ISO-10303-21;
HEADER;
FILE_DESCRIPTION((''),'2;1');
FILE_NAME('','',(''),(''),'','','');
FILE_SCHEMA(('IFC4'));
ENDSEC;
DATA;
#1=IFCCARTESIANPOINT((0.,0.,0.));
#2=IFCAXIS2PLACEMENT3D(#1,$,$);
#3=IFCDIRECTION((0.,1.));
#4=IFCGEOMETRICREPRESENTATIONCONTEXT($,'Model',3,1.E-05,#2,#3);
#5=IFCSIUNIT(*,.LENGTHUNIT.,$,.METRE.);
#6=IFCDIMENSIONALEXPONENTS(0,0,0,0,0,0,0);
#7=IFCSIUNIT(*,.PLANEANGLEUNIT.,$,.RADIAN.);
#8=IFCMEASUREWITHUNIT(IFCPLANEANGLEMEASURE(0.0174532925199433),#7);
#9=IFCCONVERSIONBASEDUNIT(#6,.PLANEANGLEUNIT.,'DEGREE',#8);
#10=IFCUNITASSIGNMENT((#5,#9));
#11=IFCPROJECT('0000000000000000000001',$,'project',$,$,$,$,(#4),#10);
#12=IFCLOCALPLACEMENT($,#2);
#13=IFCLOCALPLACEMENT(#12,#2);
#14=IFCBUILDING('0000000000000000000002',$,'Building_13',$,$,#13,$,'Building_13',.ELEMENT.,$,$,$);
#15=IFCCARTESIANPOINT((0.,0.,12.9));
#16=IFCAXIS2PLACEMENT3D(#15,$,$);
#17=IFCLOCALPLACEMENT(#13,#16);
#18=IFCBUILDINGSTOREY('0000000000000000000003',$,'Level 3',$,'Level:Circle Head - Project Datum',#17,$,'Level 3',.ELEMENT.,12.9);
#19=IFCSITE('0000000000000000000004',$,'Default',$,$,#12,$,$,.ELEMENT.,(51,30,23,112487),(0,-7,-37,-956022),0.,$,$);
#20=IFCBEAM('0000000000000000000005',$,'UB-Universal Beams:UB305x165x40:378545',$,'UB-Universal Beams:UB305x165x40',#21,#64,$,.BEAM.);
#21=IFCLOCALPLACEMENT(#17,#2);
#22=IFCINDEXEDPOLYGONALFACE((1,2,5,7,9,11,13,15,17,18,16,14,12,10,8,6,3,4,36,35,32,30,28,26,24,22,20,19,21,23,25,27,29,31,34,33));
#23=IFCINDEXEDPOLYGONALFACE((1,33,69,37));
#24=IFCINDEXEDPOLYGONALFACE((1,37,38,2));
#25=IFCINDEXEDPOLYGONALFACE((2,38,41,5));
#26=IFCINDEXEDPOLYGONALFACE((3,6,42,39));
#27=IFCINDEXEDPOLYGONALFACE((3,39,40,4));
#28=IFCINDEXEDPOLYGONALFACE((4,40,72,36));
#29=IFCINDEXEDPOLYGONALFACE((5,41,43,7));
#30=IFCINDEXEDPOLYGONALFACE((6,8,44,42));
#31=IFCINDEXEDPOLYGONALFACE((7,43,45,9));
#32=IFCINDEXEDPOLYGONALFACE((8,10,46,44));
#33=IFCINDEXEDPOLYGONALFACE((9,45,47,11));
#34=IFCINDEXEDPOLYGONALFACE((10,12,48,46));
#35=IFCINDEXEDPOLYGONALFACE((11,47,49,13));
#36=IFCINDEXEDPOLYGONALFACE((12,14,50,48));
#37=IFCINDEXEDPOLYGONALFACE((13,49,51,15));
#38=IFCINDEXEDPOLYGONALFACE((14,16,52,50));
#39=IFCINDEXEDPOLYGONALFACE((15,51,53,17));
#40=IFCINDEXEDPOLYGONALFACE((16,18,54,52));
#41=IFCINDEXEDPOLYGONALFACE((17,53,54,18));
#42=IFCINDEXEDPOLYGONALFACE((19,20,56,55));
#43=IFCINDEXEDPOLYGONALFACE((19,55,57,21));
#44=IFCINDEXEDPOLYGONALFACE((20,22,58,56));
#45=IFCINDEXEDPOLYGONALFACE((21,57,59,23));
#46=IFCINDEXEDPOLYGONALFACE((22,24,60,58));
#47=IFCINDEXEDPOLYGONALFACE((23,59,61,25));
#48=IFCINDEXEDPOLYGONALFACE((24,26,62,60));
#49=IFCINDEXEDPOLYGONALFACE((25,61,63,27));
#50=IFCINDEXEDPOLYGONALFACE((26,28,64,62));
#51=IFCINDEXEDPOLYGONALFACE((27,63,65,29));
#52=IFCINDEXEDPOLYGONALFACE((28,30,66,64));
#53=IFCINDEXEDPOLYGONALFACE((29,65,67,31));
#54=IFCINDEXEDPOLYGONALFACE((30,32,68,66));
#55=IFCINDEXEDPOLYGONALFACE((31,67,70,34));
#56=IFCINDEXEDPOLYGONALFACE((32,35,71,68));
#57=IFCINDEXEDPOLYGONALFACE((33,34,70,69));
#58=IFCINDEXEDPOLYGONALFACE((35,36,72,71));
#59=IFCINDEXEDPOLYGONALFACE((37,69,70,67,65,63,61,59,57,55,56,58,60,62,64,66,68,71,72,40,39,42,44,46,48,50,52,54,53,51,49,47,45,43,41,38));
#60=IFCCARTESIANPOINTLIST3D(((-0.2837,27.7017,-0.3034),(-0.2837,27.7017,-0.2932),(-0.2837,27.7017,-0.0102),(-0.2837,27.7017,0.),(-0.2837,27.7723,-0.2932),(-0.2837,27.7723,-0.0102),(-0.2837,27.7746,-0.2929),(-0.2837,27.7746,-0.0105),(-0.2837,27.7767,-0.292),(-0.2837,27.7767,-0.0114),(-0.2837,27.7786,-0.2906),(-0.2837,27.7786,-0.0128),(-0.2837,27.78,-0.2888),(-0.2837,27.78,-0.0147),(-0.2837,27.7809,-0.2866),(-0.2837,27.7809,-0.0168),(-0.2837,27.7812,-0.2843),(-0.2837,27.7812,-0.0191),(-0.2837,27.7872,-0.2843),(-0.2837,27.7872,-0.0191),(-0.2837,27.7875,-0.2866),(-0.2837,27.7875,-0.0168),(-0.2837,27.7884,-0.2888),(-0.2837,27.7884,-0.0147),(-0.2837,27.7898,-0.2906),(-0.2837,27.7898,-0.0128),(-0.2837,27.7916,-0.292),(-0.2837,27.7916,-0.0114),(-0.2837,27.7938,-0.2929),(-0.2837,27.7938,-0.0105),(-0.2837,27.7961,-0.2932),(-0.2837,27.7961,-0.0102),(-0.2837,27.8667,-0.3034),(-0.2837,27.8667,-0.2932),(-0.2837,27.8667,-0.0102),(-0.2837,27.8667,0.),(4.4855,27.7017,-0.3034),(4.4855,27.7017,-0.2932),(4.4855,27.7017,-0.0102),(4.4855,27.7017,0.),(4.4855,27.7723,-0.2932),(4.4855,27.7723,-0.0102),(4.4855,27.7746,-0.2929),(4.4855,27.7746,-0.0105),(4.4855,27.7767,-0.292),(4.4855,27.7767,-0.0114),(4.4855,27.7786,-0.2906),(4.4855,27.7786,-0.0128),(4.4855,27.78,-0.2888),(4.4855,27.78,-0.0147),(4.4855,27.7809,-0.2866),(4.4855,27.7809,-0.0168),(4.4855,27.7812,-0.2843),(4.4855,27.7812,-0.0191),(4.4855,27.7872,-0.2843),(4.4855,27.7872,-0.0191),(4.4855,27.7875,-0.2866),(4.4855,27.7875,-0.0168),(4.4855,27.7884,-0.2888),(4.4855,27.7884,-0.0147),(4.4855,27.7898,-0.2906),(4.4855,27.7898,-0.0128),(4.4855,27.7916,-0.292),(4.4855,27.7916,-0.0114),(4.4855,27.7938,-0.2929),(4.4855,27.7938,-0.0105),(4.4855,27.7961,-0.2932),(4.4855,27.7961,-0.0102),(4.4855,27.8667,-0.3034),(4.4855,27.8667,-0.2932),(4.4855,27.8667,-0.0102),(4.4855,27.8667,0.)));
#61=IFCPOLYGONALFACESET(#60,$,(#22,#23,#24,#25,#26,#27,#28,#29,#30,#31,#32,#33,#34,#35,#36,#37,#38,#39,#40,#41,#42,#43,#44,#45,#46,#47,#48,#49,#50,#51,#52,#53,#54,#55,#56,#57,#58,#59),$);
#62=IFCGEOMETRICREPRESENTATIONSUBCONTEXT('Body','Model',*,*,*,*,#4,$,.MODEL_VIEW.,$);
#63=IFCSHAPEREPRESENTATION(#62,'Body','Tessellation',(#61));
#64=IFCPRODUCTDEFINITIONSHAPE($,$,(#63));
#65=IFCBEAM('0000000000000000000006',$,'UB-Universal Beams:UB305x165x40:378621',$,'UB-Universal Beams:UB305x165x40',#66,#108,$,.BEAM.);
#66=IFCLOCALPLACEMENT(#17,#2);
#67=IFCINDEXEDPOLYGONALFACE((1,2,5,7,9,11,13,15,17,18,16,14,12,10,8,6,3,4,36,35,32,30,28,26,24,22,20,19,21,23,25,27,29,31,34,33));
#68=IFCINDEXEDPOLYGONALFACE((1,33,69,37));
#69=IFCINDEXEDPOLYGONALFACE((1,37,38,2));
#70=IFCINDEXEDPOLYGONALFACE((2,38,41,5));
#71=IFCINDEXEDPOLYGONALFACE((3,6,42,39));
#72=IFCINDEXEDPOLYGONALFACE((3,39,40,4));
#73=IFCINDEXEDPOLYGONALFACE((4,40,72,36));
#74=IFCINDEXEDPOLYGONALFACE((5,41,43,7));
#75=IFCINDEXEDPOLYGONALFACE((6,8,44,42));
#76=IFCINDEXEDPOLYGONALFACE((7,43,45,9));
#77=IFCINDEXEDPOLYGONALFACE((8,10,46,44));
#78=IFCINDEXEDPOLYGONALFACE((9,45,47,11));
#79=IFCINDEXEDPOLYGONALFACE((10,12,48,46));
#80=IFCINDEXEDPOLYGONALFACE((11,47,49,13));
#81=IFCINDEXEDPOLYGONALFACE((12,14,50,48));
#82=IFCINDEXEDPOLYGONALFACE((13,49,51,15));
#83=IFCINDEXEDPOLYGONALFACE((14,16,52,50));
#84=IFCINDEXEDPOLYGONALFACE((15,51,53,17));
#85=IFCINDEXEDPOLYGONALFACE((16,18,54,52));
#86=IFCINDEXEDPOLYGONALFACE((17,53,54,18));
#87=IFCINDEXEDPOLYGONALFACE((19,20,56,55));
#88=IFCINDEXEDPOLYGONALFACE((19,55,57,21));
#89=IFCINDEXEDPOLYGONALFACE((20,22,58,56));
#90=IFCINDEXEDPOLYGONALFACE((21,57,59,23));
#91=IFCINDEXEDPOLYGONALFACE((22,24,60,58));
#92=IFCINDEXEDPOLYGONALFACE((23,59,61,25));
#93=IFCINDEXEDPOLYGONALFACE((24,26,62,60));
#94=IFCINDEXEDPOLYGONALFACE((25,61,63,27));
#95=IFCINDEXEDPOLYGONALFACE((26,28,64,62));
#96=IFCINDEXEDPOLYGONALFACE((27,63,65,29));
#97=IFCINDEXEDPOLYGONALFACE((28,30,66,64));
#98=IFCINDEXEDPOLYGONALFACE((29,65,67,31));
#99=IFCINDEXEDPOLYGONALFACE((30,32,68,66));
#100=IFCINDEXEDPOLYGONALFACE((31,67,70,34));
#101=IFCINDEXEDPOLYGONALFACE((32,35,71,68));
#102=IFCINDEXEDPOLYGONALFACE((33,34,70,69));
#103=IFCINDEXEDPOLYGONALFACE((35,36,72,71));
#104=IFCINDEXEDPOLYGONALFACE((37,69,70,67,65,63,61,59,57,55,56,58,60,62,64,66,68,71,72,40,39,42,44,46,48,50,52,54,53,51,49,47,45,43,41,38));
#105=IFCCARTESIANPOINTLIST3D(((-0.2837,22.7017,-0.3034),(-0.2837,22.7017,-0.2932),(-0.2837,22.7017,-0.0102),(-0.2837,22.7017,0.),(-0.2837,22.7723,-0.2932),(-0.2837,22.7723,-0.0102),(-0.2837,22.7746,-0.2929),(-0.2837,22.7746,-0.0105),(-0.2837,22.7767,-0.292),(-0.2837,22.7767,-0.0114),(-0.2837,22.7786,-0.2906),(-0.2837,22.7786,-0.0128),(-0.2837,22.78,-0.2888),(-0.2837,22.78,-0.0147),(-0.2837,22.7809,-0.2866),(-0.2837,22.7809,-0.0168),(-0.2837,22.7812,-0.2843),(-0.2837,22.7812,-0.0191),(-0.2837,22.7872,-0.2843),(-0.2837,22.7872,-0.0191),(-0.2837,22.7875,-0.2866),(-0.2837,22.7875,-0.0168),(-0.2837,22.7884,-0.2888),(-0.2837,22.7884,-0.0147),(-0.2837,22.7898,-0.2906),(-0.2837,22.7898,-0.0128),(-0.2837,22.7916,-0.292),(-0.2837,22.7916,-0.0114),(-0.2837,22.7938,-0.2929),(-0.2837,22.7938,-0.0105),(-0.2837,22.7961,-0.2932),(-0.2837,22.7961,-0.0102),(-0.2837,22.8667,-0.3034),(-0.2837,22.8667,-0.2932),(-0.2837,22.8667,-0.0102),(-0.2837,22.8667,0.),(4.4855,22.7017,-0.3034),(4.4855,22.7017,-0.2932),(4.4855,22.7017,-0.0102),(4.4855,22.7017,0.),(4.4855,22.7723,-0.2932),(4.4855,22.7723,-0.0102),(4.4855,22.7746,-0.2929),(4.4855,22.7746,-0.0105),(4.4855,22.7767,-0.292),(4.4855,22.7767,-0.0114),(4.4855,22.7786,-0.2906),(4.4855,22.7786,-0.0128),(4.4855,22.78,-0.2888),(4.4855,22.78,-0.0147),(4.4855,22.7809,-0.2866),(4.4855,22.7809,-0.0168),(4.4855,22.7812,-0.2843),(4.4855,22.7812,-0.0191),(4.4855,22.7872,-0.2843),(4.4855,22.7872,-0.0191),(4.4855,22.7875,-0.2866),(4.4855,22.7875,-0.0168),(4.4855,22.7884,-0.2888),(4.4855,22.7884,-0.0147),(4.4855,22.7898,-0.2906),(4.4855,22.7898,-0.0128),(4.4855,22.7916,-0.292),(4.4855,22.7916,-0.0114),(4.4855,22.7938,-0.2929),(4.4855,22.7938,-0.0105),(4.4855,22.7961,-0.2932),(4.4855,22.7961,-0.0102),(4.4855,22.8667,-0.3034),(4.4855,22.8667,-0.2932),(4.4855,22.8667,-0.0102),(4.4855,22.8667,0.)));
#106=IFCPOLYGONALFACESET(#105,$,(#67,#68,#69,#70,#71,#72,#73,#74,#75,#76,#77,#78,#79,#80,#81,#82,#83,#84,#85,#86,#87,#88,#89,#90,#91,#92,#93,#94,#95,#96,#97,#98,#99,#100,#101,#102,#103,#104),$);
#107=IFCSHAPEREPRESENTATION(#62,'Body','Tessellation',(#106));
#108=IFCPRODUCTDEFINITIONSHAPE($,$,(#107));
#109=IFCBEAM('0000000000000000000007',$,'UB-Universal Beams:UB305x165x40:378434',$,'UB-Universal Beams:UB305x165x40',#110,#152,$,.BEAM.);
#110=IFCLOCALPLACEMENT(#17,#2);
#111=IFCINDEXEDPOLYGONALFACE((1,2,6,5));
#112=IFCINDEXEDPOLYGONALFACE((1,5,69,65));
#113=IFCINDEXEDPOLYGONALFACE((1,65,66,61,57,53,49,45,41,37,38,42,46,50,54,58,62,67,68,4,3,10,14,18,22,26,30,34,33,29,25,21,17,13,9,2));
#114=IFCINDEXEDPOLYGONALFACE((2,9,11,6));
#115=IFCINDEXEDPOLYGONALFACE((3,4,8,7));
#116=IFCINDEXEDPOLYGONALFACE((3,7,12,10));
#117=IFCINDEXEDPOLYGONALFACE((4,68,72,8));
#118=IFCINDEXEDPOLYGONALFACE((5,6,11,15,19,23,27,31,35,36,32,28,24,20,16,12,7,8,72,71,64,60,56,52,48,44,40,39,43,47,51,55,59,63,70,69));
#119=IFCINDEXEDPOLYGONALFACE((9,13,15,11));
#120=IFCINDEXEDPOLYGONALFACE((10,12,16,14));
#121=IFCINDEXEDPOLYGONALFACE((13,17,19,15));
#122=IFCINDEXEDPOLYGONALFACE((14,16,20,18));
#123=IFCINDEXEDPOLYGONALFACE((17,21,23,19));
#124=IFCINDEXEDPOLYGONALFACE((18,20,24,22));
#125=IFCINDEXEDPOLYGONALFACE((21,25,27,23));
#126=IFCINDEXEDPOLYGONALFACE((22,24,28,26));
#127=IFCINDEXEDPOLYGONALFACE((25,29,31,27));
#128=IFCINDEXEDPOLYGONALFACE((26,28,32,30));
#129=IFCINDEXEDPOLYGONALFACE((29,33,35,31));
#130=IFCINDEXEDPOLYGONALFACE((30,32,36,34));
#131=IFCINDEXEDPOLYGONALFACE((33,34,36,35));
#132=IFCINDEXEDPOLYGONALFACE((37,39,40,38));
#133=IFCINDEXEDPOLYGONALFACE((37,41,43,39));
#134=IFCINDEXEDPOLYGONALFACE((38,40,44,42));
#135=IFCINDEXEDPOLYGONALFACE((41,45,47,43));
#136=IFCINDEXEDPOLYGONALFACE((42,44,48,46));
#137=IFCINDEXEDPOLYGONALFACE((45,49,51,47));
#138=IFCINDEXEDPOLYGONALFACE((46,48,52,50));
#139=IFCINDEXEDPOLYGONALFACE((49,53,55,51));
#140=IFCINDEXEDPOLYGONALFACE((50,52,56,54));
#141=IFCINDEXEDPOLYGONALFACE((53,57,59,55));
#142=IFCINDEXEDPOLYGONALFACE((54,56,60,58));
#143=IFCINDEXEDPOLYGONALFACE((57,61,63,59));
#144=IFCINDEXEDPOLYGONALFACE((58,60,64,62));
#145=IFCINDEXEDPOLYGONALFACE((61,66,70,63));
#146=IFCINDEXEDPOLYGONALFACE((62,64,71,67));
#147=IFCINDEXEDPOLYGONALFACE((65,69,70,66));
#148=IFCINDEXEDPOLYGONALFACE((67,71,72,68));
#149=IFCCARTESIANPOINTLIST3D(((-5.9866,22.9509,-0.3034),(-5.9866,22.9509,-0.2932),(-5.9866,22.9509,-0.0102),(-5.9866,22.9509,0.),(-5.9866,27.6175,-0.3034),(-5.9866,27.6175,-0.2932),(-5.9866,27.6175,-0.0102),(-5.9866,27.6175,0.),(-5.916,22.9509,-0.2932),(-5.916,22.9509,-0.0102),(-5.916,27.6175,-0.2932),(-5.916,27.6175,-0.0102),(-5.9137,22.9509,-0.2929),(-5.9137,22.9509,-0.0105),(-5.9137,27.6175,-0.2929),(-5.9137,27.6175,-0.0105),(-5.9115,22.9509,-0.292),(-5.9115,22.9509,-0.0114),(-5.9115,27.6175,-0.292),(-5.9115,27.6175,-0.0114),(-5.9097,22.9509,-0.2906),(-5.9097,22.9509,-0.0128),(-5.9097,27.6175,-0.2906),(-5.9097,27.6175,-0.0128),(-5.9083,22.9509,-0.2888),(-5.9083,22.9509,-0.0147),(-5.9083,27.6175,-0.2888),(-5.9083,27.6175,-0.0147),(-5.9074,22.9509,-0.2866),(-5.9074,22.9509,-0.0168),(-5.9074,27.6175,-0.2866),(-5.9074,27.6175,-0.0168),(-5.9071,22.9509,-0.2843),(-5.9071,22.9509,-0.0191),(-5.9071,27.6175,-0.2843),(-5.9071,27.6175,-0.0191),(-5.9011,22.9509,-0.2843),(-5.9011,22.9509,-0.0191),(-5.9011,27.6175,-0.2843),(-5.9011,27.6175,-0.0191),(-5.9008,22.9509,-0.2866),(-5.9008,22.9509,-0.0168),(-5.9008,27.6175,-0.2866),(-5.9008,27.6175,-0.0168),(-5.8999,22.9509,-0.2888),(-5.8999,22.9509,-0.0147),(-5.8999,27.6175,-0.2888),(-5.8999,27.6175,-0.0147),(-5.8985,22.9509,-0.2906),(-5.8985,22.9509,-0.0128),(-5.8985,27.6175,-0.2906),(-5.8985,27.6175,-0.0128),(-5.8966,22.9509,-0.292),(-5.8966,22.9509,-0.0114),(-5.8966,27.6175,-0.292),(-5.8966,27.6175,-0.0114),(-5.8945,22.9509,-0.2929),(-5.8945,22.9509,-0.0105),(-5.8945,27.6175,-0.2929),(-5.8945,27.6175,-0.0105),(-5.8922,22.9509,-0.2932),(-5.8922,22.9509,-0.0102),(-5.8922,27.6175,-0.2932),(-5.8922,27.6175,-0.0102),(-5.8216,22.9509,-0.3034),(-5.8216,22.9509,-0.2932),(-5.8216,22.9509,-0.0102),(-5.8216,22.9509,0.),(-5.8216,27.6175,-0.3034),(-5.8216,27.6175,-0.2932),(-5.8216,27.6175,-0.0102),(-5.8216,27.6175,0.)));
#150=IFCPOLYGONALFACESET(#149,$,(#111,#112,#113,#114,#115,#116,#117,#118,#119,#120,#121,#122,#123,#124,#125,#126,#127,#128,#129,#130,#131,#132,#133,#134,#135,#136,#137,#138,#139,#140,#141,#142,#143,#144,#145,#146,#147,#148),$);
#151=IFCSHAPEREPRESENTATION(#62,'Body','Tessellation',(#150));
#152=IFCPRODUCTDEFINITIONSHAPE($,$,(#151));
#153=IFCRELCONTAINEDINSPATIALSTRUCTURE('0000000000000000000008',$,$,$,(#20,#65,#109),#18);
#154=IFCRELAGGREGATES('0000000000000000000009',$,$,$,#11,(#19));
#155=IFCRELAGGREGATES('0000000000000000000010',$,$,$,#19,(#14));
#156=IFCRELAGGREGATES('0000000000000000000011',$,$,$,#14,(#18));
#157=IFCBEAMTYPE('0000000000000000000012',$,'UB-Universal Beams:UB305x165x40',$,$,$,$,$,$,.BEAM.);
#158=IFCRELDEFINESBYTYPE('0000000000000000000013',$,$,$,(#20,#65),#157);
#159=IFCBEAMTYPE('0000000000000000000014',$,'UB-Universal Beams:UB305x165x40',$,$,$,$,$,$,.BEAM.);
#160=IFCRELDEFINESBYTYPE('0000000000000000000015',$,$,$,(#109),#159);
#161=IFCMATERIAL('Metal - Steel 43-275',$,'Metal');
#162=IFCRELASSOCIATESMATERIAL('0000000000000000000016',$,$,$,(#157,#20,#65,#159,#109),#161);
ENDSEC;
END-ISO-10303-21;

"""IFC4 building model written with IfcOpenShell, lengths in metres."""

from ifc_helpers import new_model, entity, si_unit, converted_unit, direction, frame, origin, place, context, subcontext, project, spatial, line, arc, indexed_curve, outline, extrude, source, transform, mapped, material, type_object, type_shapes, element, save


model = new_model("IFC4")

# Units and contexts
model_context = context("Model", 3, precision=1e-05, world=origin(), true_north=direction((0.0, 1.0)))
body_context = subcontext(model_context, "Body", "Model", "MODEL_VIEW")
ifc_project = project(units=[si_unit("LENGTHUNIT", "METRE"), converted_unit("PLANEANGLEUNIT", "DEGREE", entity("IfcPlaneAngleMeasure", 0.0174532925199433), si_unit("PLANEANGLEUNIT", "RADIAN"), dimensions=[0, 0, 0, 0, 0, 0, 0])], contexts=[model_context])

# Site, building, storey
site_placement = place(None, origin())
site = spatial("IfcSite", under=ifc_project, at=site_placement, Name="Default", CompositionType="ELEMENT", RefLatitude=(51, 30, 23, 112487), RefLongitude=(0, -7, -37, -956022), RefElevation=0.0)
building_placement = place(site_placement, origin())
building = spatial("IfcBuilding", under=site, at=building_placement, Name="Building_13", LongName="Building_13", CompositionType="ELEMENT")
storey_placement = place(building_placement, frame((0.0, 0.0, 12.9)))
storey = spatial("IfcBuildingStorey", under=building, at=storey_placement, Name="Level 3", ObjectType="Level:Circle Head - Project Datum", LongName="Level 3", CompositionType="ELEMENT", Elevation=12.9)

# Beams
ifc_material_1 = material(Name="Metal - Steel 43-275", Category="Metal")
beam_type_1 = type_object("IfcBeamType", Name="UB-Universal Beams:UB305x165x40", PredefinedType="BEAM", material=ifc_material_1)
shared_shape_1 = source(origin(), body_context, "Body", "SweptSolid", [
    extrude(outline(indexed_curve([(-0.0825, -0.1415), (-0.0825, -0.1517), (0.0825, -0.1517), (0.0825, -0.1415), (0.0119, -0.1415), (0.0056, -0.1389), (0.003, -0.1326), (0.003, 0.1326), (0.0056, 0.1389), (0.0119, 0.1415), (0.0825, 0.1415), (0.0825, 0.1517), (-0.0825, 0.1517), (-0.0825, 0.1415), (-0.0119, 0.1415), (-0.0056, 0.1389), (-0.003, 0.1326), (-0.003, -0.1326), (-0.0056, -0.1389), (-0.0119, -0.1415)], segments=[line(1, 2, 3, 4, 5), arc(5, 6, 7), line(7, 8), arc(8, 9, 10), line(10, 11, 12, 13, 14, 15), arc(15, 16, 17), line(17, 18), arc(18, 19, 20), line(20, 1)], self_intersect=False)), frame((-2.3846, 0.0, 0.0), z_axis=(-1.0, 0.0, 0.0), x_axis=(0.0, -1.0, 0.0)), (0.0, 0.0, -1.0), 4.7692),
])
type_shapes(beam_type_1, [shared_shape_1])
beam_1_placement = place(storey_placement, frame((2.1009, 27.7842, -0.1517)))
element("IfcBeam", 1, at=beam_1_placement, inside=storey, type_object=beam_type_1, material=ifc_material_1, Name="UB-Universal Beams:UB305x165x40:378545", ObjectType="UB-Universal Beams:UB305x165x40", PredefinedType="BEAM", context=body_context, shape_type="MappedRepresentation", body=[
    mapped(shared_shape_1, transform((0.0, 0.0, 0.0), scale=1.0)),
])
beam_2_placement = place(storey_placement, frame((2.1009, 22.7842, -0.1517), z_axis=(0.0, 0.0, 1.0), x_axis=(-1.0, 0.0, 0.0)))
element("IfcBeam", 2, at=beam_2_placement, inside=storey, type_object=beam_type_1, material=ifc_material_1, Name="UB-Universal Beams:UB305x165x40:378621", ObjectType="UB-Universal Beams:UB305x165x40", PredefinedType="BEAM", context=body_context, shape_type="MappedRepresentation", body=[
    mapped(shared_shape_1, transform((0.0, 0.0, 0.0), scale=1.0)),
])
beam_type_2 = type_object("IfcBeamType", Name="UB-Universal Beams:UB305x165x40", PredefinedType="BEAM", material=ifc_material_1)
shared_shape_2 = source(origin(), body_context, "Body", "SweptSolid", [
    extrude(outline(indexed_curve([(-0.0825, -0.1415), (-0.0825, -0.1517), (0.0825, -0.1517), (0.0825, -0.1415), (0.0119, -0.1415), (0.0056, -0.1389), (0.003, -0.1326), (0.003, 0.1326), (0.0056, 0.1389), (0.0119, 0.1415), (0.0825, 0.1415), (0.0825, 0.1517), (-0.0825, 0.1517), (-0.0825, 0.1415), (-0.0119, 0.1415), (-0.0056, 0.1389), (-0.003, 0.1326), (-0.003, -0.1326), (-0.0056, -0.1389), (-0.0119, -0.1415)], segments=[line(1, 2, 3, 4, 5), arc(5, 6, 7), line(7, 8), arc(8, 9, 10), line(10, 11, 12, 13, 14, 15), arc(15, 16, 17), line(17, 18), arc(18, 19, 20), line(20, 1)], self_intersect=False)), frame((-2.3333, 0.0, 0.0), z_axis=(-1.0, 0.0, 0.0), x_axis=(0.0, -1.0, 0.0)), (0.0, 0.0, -1.0), 4.6666),
])
type_shapes(beam_type_2, [shared_shape_2])
for number, where, z_axis, x_axis, name in (
    (3, (-5.9041, 25.2842, -0.1517), (0.0, 0.0, 1.0), (0.0, -1.0, 0.0), "UB-Universal Beams:UB305x165x40:378434"),
):
    element("IfcBeam", number, at=place(storey_placement, frame(where, z_axis=z_axis, x_axis=x_axis)), inside=storey, type_object=beam_type_2, material=ifc_material_1, Name=name, ObjectType="UB-Universal Beams:UB305x165x40", PredefinedType="BEAM", context=body_context, shape_type="MappedRepresentation", body=[
        mapped(shared_shape_2, transform((0.0, 0.0, 0.0), scale=1.0)),
    ])

save(model, "model.ifc")
